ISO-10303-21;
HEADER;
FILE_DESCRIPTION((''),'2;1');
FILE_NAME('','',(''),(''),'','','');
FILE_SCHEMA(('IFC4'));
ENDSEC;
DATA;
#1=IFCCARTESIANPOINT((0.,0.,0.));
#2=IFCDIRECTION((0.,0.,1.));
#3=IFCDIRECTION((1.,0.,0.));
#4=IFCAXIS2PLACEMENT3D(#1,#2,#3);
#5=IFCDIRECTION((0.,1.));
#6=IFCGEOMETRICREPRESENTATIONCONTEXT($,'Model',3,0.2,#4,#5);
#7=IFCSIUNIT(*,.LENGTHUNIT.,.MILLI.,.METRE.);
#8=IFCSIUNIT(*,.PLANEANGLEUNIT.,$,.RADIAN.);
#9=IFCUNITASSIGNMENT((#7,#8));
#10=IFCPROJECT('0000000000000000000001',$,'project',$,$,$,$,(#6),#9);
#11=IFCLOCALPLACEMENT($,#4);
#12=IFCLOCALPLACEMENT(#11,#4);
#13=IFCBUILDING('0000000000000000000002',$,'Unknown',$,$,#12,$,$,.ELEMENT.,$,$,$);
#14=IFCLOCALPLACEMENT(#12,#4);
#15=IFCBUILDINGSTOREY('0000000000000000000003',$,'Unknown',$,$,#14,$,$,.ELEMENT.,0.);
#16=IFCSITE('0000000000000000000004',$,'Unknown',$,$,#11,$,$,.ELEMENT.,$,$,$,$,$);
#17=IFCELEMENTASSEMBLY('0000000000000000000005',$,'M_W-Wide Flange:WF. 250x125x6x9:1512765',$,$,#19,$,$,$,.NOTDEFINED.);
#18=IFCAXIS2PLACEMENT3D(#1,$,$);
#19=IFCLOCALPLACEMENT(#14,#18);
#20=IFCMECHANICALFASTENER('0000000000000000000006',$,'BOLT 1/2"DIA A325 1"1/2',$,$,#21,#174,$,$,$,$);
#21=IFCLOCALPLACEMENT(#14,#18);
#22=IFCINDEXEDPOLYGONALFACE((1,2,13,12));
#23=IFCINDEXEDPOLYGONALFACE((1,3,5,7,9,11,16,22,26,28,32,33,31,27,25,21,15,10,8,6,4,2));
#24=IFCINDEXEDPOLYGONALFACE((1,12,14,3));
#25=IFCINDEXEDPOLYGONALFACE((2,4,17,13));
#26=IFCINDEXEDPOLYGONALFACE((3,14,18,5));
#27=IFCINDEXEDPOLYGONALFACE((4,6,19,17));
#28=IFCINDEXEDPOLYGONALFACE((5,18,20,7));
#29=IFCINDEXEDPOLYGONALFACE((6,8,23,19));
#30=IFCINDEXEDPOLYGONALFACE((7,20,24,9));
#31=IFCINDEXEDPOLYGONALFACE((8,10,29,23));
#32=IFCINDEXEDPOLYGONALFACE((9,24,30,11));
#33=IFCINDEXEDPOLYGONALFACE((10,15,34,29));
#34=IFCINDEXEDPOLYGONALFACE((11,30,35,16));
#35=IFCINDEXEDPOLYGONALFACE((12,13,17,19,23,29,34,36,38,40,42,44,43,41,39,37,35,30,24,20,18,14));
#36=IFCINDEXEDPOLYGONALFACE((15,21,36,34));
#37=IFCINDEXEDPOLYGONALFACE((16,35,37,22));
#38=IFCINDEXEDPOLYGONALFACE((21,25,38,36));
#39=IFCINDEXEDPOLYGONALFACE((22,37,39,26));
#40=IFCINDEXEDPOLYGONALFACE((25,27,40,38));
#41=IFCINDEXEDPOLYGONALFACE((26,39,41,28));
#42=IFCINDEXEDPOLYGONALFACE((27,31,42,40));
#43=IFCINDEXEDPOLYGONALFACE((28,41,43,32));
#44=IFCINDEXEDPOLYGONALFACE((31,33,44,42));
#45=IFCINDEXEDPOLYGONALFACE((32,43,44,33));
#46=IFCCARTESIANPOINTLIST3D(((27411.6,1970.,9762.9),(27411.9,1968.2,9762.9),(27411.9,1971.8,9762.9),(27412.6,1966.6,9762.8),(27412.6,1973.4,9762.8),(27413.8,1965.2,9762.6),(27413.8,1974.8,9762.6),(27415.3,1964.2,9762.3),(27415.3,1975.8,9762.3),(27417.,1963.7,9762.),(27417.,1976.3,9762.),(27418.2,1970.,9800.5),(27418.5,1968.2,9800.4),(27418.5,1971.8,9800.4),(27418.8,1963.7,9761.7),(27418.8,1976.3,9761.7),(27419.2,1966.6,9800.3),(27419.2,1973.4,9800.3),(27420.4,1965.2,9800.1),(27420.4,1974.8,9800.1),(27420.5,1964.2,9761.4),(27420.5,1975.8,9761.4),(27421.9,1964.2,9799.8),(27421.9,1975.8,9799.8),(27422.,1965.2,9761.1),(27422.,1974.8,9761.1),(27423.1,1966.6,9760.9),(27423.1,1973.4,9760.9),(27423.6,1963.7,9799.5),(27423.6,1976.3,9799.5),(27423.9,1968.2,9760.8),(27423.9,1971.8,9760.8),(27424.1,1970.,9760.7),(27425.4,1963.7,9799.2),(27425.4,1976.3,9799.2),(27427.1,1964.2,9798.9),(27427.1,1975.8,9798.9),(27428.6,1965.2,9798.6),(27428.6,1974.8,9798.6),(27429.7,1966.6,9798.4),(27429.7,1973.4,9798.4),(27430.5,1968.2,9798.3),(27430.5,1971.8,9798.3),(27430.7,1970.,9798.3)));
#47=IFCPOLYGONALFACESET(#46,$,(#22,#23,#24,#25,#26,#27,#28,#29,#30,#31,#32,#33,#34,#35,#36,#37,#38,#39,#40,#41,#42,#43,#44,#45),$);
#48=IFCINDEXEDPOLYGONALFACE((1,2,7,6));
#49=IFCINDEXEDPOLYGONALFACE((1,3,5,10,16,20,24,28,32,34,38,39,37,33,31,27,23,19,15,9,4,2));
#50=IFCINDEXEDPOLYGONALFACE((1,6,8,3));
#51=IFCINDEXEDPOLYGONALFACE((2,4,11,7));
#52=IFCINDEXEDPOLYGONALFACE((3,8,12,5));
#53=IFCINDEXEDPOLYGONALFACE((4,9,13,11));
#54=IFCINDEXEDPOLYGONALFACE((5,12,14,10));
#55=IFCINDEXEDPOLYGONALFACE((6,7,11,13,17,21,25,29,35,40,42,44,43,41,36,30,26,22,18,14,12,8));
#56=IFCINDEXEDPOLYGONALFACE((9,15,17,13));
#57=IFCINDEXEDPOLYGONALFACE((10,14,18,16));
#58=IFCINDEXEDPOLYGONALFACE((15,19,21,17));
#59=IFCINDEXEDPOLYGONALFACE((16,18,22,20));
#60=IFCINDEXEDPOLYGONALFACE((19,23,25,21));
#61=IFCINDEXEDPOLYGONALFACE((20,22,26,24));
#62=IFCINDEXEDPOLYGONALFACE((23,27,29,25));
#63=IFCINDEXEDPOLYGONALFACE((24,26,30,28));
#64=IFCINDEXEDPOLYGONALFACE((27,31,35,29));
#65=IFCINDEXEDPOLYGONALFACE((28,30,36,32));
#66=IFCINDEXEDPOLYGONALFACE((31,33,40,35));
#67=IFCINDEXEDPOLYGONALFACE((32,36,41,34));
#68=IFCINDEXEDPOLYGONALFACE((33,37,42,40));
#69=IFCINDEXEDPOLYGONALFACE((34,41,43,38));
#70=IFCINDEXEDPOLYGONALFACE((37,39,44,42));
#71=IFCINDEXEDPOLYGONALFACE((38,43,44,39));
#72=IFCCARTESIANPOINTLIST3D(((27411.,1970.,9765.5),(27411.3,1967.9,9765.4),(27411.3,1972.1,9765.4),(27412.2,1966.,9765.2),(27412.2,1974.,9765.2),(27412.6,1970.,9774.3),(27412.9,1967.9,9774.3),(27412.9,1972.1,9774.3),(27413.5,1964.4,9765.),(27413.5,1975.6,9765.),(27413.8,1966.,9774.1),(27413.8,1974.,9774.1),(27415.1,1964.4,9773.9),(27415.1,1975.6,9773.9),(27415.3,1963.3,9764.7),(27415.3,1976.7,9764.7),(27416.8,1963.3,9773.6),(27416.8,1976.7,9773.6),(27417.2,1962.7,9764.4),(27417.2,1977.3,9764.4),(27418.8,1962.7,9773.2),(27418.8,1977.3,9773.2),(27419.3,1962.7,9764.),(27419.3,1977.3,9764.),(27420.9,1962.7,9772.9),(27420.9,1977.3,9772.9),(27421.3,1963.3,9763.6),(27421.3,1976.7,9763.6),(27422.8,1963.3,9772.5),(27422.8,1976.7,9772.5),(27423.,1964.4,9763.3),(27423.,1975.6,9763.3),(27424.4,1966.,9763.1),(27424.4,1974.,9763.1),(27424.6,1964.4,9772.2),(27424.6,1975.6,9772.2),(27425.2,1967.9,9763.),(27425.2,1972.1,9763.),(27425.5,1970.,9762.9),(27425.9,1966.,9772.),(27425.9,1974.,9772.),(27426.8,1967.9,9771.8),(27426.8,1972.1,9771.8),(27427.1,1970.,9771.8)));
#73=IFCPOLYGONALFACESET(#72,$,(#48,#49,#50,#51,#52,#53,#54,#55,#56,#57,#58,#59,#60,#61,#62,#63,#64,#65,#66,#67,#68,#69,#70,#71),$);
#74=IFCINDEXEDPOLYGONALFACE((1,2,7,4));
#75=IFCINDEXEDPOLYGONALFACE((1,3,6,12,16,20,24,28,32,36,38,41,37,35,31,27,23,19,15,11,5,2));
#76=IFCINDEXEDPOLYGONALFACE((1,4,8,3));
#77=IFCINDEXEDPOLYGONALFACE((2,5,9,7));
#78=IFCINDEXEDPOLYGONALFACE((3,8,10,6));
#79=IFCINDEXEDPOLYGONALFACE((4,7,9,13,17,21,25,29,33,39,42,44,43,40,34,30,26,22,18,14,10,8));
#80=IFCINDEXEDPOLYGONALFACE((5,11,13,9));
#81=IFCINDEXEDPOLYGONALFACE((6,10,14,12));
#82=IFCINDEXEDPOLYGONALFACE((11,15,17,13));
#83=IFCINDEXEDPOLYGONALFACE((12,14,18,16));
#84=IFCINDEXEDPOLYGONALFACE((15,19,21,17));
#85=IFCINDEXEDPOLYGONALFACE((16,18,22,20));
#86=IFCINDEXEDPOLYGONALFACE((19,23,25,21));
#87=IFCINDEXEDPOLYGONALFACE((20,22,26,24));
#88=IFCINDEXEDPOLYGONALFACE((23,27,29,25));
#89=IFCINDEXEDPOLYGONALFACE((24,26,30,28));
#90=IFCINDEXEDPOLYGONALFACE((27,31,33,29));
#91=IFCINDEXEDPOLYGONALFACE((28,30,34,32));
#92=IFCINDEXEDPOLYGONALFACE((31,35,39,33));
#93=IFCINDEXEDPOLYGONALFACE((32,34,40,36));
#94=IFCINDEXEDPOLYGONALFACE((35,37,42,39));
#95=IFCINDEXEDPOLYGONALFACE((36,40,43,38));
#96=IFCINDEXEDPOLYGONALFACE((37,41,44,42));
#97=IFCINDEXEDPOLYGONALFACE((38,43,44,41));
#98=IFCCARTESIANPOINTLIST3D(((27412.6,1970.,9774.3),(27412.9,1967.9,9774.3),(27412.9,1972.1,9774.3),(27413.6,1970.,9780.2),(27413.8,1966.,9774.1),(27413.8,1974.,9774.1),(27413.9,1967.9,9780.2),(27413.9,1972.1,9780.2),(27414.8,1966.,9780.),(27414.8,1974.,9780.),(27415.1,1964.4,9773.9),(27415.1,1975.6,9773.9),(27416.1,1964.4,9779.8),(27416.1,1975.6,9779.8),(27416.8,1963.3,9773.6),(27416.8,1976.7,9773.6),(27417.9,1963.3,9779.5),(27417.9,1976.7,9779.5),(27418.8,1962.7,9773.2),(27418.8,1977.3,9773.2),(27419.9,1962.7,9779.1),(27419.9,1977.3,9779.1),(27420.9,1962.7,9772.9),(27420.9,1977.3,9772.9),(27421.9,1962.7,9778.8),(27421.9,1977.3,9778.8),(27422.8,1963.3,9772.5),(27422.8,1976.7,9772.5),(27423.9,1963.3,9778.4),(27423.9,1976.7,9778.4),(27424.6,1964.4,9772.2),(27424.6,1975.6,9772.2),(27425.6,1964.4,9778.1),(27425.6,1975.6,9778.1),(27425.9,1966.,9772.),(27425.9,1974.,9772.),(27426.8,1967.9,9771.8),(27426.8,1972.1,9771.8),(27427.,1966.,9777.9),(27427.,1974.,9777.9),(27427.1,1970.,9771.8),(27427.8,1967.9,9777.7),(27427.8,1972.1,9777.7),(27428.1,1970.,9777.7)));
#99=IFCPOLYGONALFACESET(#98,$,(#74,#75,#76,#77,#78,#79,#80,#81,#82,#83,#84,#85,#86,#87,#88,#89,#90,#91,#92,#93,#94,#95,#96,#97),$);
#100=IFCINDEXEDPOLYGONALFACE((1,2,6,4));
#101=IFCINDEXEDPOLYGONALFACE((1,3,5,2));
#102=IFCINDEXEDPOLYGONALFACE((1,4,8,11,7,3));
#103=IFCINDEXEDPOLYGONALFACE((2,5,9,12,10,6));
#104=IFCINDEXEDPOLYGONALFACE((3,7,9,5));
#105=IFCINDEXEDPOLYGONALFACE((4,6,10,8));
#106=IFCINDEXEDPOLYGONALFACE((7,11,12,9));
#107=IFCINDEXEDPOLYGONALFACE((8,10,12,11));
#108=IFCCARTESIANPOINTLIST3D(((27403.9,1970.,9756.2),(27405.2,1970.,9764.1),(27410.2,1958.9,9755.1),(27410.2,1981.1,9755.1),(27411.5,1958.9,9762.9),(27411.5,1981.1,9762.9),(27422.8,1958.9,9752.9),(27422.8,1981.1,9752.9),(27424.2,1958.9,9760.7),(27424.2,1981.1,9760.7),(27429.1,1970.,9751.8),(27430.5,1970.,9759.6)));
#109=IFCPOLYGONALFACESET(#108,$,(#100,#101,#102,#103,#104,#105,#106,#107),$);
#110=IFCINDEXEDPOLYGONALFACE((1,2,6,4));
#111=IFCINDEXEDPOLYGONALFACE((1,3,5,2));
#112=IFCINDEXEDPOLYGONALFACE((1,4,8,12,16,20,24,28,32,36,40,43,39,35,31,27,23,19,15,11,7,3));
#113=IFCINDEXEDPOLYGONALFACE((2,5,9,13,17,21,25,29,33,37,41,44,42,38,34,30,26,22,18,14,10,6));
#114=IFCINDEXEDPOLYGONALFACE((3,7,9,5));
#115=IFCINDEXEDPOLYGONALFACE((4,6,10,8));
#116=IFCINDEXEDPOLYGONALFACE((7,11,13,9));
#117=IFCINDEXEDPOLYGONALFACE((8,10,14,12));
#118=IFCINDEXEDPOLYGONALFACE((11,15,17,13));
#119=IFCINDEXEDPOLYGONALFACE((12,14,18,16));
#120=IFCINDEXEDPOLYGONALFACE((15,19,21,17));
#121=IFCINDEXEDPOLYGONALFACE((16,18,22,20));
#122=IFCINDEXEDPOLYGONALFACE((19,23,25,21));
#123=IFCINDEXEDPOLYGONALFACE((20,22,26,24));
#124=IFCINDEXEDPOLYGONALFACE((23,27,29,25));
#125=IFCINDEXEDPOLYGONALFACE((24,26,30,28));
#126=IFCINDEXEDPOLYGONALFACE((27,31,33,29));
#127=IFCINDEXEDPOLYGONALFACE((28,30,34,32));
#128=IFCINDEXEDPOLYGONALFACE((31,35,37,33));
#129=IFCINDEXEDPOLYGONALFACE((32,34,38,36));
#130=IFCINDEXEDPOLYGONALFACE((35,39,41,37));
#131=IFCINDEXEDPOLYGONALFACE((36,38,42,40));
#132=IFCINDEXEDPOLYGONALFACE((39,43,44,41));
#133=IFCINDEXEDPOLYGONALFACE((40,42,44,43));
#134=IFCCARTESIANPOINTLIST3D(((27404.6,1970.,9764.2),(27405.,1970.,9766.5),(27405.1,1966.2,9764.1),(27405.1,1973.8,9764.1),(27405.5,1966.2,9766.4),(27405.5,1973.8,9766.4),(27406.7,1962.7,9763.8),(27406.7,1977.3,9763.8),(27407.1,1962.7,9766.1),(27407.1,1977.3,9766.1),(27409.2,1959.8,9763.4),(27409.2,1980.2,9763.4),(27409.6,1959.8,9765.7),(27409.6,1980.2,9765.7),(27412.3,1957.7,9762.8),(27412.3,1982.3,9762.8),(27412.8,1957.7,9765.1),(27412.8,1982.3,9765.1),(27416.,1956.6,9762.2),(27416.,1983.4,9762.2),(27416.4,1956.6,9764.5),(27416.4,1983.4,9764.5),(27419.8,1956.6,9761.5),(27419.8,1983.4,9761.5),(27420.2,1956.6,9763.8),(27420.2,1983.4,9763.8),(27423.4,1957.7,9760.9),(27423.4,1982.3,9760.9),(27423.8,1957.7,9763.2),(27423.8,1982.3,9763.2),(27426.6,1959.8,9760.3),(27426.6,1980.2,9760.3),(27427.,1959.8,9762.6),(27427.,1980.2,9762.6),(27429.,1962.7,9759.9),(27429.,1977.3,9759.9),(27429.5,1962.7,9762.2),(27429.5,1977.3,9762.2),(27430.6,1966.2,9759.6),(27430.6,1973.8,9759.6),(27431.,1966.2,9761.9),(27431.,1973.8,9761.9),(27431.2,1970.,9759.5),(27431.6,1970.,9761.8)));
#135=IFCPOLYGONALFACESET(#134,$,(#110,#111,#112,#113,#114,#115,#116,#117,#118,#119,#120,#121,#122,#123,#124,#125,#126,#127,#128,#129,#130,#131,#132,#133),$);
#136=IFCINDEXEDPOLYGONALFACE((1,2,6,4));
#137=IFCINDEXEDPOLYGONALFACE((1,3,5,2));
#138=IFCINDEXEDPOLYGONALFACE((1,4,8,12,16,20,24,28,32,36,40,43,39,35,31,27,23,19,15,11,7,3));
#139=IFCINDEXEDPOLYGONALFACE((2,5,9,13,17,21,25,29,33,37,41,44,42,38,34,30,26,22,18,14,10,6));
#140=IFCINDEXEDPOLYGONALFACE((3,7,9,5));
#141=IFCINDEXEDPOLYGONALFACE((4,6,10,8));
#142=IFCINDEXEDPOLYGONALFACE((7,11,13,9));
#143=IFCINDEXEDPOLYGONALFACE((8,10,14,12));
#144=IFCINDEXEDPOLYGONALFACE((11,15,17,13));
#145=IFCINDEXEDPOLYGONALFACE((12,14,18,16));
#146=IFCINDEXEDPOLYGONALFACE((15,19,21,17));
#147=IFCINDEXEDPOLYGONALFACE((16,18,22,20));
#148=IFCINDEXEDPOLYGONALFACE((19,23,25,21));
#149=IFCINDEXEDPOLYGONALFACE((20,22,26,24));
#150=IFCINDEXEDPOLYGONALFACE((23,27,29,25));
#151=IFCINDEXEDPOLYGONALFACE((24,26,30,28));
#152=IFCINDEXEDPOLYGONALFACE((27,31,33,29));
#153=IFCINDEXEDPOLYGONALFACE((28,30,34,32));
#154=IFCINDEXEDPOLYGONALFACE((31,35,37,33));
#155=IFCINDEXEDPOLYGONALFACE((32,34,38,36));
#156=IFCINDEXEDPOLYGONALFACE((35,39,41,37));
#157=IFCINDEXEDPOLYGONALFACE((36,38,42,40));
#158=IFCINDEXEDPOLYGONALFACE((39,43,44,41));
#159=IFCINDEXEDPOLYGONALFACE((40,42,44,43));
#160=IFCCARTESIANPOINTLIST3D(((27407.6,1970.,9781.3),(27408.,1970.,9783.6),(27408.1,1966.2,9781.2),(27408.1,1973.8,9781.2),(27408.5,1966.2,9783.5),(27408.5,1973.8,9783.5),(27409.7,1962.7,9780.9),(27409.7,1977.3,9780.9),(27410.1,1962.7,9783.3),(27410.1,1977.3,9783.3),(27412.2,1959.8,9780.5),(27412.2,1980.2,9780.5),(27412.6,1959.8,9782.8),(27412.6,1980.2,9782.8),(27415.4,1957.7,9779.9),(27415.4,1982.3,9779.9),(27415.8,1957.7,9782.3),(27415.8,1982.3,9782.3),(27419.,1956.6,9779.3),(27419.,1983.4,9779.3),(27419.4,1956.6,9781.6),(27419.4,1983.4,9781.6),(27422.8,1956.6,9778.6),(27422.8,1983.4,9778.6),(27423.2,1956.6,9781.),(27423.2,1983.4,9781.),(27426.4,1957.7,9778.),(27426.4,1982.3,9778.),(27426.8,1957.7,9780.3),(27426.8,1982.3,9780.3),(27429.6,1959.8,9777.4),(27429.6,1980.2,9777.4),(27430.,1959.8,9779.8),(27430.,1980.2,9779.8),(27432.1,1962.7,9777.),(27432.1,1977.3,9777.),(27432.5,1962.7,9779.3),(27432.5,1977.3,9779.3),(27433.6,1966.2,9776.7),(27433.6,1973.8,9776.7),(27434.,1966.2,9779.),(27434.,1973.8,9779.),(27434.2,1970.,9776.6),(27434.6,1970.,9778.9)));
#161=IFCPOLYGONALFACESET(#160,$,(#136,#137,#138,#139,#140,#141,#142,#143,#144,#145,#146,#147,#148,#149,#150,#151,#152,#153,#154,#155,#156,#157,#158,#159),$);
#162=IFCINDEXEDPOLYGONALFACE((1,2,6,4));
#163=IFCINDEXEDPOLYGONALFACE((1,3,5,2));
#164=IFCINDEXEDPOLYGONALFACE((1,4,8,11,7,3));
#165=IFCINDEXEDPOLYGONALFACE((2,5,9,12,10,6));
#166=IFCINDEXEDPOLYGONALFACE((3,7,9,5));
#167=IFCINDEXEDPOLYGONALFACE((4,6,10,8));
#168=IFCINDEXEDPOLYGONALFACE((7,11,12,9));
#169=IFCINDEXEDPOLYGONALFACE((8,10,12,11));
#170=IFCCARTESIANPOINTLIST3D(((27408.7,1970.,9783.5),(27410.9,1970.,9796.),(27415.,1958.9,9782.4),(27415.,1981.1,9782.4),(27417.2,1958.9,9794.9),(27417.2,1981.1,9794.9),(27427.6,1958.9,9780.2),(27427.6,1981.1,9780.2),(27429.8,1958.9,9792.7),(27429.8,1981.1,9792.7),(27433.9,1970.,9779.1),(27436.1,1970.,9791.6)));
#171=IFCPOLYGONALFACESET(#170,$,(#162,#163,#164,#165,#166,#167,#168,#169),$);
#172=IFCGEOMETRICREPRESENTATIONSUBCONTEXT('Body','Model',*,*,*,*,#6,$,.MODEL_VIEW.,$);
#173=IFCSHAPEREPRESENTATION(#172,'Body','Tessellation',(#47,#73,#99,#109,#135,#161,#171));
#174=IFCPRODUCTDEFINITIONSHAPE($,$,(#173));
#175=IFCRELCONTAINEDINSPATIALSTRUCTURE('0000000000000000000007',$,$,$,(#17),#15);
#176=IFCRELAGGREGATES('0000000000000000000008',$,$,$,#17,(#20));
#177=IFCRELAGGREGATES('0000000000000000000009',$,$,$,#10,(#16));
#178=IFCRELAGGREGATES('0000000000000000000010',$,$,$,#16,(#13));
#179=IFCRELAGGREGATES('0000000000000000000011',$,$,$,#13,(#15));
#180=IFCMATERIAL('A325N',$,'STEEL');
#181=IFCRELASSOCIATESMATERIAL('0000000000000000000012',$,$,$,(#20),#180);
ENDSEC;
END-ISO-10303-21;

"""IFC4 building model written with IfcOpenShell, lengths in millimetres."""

from ifc_helpers import new_model, si_unit, direction, frame, origin_with_axes, place, context, subcontext, project, spatial, line, arc, indexed_curve, outline, extrude, source, transform, mapped, material, element, aggregate, save


model = new_model("IFC4")

# Units and contexts
model_context = context("Model", 3, precision=0.2, world=origin_with_axes(), true_north=direction((0.0, 1.0)))
body_context = subcontext(model_context, "Body", "Model", "MODEL_VIEW")
ifc_project = project(units=[si_unit("LENGTHUNIT", "METRE", prefix="MILLI"), si_unit("PLANEANGLEUNIT", "RADIAN")], contexts=[model_context])

# Site, building, storey
site_placement = place(None, origin_with_axes())
site = spatial("IfcSite", under=ifc_project, at=site_placement, Name="Unknown", CompositionType="ELEMENT")
building_placement = place(site_placement, origin_with_axes())
building = spatial("IfcBuilding", under=site, at=building_placement, Name="Unknown", CompositionType="ELEMENT")
storey_placement = place(building_placement, origin_with_axes())
storey = spatial("IfcBuildingStorey", under=building, at=storey_placement, Name="Unknown", CompositionType="ELEMENT", Elevation=0.0)

# Shared definitions
ifc_material_1 = material(Name="A325N", Category="STEEL")
shared_shape = source(origin_with_axes(), body_context, "Body", "SweptSolid", [
    extrude(outline(indexed_curve([(6.3, 0.0), (0.0, 6.3), (-6.3, 0.0), (0.0, -6.3)], segments=[arc(1, 2, 3), arc(3, 4, 1)])), frame((0.0, 0.0, 17.4), z_axis=(0.0, 0.0, -1.0), x_axis=(0.0, 1.0, 0.0)), (0.0, 0.0, 1.0), 38.1),
    extrude(outline(indexed_curve([(7.3, 0.0), (0.0, 7.3), (-7.3, 0.0), (0.0, -7.3)], segments=[arc(1, 2, 3), arc(3, 4, 1)])), frame((0.0, 0.0, 15.0), z_axis=(0.0, 0.0, -1.0), x_axis=(0.0, 1.0, 0.0)), (0.0, 0.0, 1.0), 9.0),
    extrude(outline(indexed_curve([(7.3, 0.0), (0.0, 7.3), (-7.3, 0.0), (0.0, -7.3)], segments=[arc(1, 2, 3), arc(3, 4, 1)])), frame((0.0, 0.0, 6.0), z_axis=(0.0, 0.0, -1.0), x_axis=(0.0, 1.0, 0.0)), (0.0, 0.0, 1.0), 6.0),
    extrude(outline(indexed_curve([(12.8, 0.0), (6.4, 11.1), (-6.4, 11.1), (-12.8, 0.0), (-6.4, -11.1), (6.4, -11.1)], segments=[line(1, 2, 3, 4, 5, 6, 1)])), frame((0.0, 0.0, 25.3), z_axis=(0.0, 0.0, -1.0), x_axis=(0.0, 1.0, 0.0)), (0.0, 0.0, 1.0), 7.9),
    extrude(outline(indexed_curve([(13.5, 0.0), (0.0, 13.5), (-13.5, 0.0), (0.0, -13.5)], segments=[arc(1, 2, 3), arc(3, 4, 1)])), frame((0.0, 0.0, 17.4), z_axis=(0.0, 0.0, -1.0), x_axis=(0.0, 1.0, 0.0)), (0.0, 0.0, 1.0), 2.4),
    extrude(outline(indexed_curve([(13.5, 0.0), (0.0, 13.5), (-13.5, 0.0), (0.0, -13.5)], segments=[arc(1, 2, 3), arc(3, 4, 1)])), frame((0.0, 0.0, 0.0), z_axis=(0.0, 0.0, -1.0), x_axis=(0.0, 1.0, 0.0)), (0.0, 0.0, 1.0), 2.4),
    extrude(outline(indexed_curve([(12.8, 0.0), (6.4, 11.1), (-6.4, 11.1), (-12.8, 0.0), (-6.4, -11.1), (6.4, -11.1)], segments=[line(1, 2, 3, 4, 5, 6, 1)])), frame((0.0, 0.0, -2.4), z_axis=(0.0, 0.0, -1.0), x_axis=(0.0, 1.0, 0.0)), (0.0, 0.0, 1.0), 12.7),
])

# Element assembly, mechanical fastener
assembly_1_placement = place(storey_placement, frame((27430.1, 0.0, 9644.3), z_axis=(0.984808, 0.0, -0.173648), x_axis=(0.0, 1.0, 0.0)))
assembly_1 = element("IfcElementAssembly", 1, at=assembly_1_placement, inside=storey, Name="M_W-Wide Flange:WF. 250x125x6x9:1512765", PredefinedType="NOTDEFINED")
mechanical_fastener_1_placement = place(assembly_1_placement, frame((1970.0, 131.0, -32.5), z_axis=(0.0, -1.0, 0.0), x_axis=(-1.0, 0.0, 0.0)))
mechanical_fastener_1 = element("IfcMechanicalFastener", 2, at=mechanical_fastener_1_placement, material=ifc_material_1, Name="BOLT 1/2\"DIA A325 1\"1/2", context=body_context, shape_type="MappedRepresentation", body=[
    mapped(shared_shape, transform((0.0, 0.0, 0.0))),
])
aggregate(assembly_1, [mechanical_fastener_1])

save(model, "model.ifc")
